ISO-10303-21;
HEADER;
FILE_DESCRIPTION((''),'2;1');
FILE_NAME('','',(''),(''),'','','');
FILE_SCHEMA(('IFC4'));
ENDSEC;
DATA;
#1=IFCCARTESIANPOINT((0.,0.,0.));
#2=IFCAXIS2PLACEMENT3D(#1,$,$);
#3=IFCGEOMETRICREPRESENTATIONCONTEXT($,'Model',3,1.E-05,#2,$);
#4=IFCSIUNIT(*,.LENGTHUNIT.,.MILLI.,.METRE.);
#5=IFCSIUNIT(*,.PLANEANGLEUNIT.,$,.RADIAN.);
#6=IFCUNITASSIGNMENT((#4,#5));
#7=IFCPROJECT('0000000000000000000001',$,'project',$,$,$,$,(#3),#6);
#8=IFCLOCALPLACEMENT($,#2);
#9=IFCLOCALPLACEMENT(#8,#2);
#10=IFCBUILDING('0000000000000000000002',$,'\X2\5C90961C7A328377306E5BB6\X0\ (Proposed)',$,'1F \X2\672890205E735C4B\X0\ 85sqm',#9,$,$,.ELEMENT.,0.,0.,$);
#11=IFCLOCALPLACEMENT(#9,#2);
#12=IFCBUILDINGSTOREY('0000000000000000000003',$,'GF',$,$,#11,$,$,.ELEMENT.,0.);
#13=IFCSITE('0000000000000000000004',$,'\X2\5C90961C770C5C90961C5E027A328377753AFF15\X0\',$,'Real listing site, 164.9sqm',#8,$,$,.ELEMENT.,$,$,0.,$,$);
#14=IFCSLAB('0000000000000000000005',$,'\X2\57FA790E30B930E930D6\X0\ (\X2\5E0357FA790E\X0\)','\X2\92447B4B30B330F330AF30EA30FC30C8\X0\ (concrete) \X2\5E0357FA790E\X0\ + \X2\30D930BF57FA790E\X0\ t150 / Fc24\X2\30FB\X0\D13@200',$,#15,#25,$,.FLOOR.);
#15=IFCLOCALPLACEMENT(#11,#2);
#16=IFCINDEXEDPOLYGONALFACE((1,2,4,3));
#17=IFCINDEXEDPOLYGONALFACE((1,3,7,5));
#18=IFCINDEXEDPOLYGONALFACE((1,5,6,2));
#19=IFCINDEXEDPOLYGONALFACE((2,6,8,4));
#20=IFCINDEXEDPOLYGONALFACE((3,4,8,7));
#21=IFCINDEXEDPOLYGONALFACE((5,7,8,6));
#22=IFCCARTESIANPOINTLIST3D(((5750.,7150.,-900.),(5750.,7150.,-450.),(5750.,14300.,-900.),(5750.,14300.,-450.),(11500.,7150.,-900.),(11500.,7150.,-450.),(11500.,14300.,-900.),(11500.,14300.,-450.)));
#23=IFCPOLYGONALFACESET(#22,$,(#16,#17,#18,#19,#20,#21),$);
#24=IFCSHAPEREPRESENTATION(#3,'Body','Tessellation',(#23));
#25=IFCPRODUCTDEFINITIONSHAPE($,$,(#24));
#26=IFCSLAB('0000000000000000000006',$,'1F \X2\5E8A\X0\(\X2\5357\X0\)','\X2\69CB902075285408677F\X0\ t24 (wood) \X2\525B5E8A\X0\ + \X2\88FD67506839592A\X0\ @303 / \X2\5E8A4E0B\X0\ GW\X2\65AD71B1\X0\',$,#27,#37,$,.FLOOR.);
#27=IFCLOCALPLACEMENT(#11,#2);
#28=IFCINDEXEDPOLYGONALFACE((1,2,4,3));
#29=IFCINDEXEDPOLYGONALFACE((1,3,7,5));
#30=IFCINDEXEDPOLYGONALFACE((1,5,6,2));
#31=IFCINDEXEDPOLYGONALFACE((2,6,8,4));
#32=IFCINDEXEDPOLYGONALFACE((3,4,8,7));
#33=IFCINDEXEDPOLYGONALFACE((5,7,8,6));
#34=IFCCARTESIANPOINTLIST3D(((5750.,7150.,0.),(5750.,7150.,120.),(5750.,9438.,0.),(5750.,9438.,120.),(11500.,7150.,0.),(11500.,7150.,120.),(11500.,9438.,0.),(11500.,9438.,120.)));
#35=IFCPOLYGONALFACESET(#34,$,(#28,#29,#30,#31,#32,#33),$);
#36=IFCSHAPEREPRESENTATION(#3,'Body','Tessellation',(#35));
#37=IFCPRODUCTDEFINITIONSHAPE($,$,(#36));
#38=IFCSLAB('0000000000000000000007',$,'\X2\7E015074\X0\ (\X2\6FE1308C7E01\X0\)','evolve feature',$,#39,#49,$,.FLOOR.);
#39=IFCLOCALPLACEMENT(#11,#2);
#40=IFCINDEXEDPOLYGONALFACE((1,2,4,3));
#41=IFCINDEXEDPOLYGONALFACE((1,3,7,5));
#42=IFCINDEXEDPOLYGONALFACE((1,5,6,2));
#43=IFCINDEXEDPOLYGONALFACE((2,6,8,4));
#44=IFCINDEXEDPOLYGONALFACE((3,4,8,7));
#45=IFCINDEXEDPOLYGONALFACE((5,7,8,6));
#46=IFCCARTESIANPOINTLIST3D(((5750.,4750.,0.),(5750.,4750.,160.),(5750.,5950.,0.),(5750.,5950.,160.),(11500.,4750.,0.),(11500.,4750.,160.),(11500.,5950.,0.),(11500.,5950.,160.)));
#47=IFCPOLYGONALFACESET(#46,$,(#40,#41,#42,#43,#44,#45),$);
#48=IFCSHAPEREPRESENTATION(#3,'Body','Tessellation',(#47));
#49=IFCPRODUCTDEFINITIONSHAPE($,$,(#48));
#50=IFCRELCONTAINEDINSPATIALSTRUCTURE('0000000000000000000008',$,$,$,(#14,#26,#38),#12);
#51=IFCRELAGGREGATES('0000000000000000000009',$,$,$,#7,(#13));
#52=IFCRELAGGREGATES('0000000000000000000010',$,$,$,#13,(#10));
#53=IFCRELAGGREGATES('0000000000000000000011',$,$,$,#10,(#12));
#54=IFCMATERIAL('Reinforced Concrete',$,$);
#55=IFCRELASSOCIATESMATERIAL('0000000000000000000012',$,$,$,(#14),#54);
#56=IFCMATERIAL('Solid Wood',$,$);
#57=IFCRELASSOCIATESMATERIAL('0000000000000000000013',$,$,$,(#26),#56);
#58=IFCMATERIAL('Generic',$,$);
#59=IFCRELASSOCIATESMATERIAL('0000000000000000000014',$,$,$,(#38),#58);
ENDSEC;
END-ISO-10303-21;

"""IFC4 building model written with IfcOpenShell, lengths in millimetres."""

from ifc_helpers import new_model, si_unit, frame, frame_2d, origin, place, context, project, spatial, rectangle, extrude, material, element, save


model = new_model("IFC4")

# Units and contexts
model_context = context("Model", 3, precision=1e-05, world=origin())
ifc_project = project(units=[si_unit("LENGTHUNIT", "METRE", prefix="MILLI"), si_unit("PLANEANGLEUNIT", "RADIAN")], contexts=[model_context])

# Site, building, storey
site_placement = place(None, origin())
site = spatial("IfcSite", under=ifc_project, at=site_placement, Name="岐阜県岐阜市稲荷町５", ObjectType="Real listing site, 164.9sqm", CompositionType="ELEMENT", RefElevation=0.0)
building_placement = place(site_placement, origin())
building = spatial("IfcBuilding", under=site, at=building_placement, Name="岐阜稲荷の家 (Proposed)", ObjectType="1F 木造平屋 85sqm", CompositionType="ELEMENT", ElevationOfRefHeight=0.0, ElevationOfTerrain=0.0)
storey_placement = place(building_placement, origin())
storey = spatial("IfcBuildingStorey", under=building, at=storey_placement, Name="GF", CompositionType="ELEMENT", Elevation=0.0)

# Slabs
ifc_material_1 = material(Name="Reinforced Concrete")
slab_1_placement = place(storey_placement, frame((2875.0, 3575.0, -450.0)))
element("IfcSlab", 1, at=slab_1_placement, inside=storey, material=ifc_material_1, Name="基礎スラブ (布基礎)", Description="鉄筋コンクリート (concrete) 布基礎 + ベタ基礎 t150 / Fc24・D13@200", PredefinedType="FLOOR", context=model_context, shape_type="SweptSolid", body=[
    extrude(rectangle(XDim=5750.0, YDim=7150.0, at=frame_2d((2875.0, 3575.0))), frame((2875.0, 3575.0, -450.0)), (0.0, 0.0, 1.0), 450.0),
])
ifc_material_2 = material(Name="Solid Wood")
slab_2_placement = place(storey_placement, frame((2875.0, 3575.0, 0.0)))
element("IfcSlab", 2, at=slab_2_placement, inside=storey, material=ifc_material_2, Name="1F 床(南)", Description="構造用合板 t24 (wood) 剛床 + 製材根太 @303 / 床下 GW断熱", PredefinedType="FLOOR", context=model_context, shape_type="SweptSolid", body=[
    extrude(rectangle(XDim=5750.0, YDim=2288.0, at=frame_2d((2875.0, 1144.0))), frame((2875.0, 3575.0, 0.0)), (0.0, 0.0, 1.0), 120.0),
])
ifc_material_3 = material(Name="Generic")
slab_3_placement = place(storey_placement, frame((2875.0, 2375.0, 0.0)))
element("IfcSlab", 3, at=slab_3_placement, inside=storey, material=ifc_material_3, Name="縁側 (濡れ縁)", Description="evolve feature", PredefinedType="FLOOR", context=model_context, shape_type="SweptSolid", body=[
    extrude(rectangle(XDim=5750.0, YDim=1200.0, at=frame_2d((2875.0, 600.0))), frame((2875.0, 2375.0, 0.0)), (0.0, 0.0, 1.0), 160.0),
])

save(model, "model.ifc")
